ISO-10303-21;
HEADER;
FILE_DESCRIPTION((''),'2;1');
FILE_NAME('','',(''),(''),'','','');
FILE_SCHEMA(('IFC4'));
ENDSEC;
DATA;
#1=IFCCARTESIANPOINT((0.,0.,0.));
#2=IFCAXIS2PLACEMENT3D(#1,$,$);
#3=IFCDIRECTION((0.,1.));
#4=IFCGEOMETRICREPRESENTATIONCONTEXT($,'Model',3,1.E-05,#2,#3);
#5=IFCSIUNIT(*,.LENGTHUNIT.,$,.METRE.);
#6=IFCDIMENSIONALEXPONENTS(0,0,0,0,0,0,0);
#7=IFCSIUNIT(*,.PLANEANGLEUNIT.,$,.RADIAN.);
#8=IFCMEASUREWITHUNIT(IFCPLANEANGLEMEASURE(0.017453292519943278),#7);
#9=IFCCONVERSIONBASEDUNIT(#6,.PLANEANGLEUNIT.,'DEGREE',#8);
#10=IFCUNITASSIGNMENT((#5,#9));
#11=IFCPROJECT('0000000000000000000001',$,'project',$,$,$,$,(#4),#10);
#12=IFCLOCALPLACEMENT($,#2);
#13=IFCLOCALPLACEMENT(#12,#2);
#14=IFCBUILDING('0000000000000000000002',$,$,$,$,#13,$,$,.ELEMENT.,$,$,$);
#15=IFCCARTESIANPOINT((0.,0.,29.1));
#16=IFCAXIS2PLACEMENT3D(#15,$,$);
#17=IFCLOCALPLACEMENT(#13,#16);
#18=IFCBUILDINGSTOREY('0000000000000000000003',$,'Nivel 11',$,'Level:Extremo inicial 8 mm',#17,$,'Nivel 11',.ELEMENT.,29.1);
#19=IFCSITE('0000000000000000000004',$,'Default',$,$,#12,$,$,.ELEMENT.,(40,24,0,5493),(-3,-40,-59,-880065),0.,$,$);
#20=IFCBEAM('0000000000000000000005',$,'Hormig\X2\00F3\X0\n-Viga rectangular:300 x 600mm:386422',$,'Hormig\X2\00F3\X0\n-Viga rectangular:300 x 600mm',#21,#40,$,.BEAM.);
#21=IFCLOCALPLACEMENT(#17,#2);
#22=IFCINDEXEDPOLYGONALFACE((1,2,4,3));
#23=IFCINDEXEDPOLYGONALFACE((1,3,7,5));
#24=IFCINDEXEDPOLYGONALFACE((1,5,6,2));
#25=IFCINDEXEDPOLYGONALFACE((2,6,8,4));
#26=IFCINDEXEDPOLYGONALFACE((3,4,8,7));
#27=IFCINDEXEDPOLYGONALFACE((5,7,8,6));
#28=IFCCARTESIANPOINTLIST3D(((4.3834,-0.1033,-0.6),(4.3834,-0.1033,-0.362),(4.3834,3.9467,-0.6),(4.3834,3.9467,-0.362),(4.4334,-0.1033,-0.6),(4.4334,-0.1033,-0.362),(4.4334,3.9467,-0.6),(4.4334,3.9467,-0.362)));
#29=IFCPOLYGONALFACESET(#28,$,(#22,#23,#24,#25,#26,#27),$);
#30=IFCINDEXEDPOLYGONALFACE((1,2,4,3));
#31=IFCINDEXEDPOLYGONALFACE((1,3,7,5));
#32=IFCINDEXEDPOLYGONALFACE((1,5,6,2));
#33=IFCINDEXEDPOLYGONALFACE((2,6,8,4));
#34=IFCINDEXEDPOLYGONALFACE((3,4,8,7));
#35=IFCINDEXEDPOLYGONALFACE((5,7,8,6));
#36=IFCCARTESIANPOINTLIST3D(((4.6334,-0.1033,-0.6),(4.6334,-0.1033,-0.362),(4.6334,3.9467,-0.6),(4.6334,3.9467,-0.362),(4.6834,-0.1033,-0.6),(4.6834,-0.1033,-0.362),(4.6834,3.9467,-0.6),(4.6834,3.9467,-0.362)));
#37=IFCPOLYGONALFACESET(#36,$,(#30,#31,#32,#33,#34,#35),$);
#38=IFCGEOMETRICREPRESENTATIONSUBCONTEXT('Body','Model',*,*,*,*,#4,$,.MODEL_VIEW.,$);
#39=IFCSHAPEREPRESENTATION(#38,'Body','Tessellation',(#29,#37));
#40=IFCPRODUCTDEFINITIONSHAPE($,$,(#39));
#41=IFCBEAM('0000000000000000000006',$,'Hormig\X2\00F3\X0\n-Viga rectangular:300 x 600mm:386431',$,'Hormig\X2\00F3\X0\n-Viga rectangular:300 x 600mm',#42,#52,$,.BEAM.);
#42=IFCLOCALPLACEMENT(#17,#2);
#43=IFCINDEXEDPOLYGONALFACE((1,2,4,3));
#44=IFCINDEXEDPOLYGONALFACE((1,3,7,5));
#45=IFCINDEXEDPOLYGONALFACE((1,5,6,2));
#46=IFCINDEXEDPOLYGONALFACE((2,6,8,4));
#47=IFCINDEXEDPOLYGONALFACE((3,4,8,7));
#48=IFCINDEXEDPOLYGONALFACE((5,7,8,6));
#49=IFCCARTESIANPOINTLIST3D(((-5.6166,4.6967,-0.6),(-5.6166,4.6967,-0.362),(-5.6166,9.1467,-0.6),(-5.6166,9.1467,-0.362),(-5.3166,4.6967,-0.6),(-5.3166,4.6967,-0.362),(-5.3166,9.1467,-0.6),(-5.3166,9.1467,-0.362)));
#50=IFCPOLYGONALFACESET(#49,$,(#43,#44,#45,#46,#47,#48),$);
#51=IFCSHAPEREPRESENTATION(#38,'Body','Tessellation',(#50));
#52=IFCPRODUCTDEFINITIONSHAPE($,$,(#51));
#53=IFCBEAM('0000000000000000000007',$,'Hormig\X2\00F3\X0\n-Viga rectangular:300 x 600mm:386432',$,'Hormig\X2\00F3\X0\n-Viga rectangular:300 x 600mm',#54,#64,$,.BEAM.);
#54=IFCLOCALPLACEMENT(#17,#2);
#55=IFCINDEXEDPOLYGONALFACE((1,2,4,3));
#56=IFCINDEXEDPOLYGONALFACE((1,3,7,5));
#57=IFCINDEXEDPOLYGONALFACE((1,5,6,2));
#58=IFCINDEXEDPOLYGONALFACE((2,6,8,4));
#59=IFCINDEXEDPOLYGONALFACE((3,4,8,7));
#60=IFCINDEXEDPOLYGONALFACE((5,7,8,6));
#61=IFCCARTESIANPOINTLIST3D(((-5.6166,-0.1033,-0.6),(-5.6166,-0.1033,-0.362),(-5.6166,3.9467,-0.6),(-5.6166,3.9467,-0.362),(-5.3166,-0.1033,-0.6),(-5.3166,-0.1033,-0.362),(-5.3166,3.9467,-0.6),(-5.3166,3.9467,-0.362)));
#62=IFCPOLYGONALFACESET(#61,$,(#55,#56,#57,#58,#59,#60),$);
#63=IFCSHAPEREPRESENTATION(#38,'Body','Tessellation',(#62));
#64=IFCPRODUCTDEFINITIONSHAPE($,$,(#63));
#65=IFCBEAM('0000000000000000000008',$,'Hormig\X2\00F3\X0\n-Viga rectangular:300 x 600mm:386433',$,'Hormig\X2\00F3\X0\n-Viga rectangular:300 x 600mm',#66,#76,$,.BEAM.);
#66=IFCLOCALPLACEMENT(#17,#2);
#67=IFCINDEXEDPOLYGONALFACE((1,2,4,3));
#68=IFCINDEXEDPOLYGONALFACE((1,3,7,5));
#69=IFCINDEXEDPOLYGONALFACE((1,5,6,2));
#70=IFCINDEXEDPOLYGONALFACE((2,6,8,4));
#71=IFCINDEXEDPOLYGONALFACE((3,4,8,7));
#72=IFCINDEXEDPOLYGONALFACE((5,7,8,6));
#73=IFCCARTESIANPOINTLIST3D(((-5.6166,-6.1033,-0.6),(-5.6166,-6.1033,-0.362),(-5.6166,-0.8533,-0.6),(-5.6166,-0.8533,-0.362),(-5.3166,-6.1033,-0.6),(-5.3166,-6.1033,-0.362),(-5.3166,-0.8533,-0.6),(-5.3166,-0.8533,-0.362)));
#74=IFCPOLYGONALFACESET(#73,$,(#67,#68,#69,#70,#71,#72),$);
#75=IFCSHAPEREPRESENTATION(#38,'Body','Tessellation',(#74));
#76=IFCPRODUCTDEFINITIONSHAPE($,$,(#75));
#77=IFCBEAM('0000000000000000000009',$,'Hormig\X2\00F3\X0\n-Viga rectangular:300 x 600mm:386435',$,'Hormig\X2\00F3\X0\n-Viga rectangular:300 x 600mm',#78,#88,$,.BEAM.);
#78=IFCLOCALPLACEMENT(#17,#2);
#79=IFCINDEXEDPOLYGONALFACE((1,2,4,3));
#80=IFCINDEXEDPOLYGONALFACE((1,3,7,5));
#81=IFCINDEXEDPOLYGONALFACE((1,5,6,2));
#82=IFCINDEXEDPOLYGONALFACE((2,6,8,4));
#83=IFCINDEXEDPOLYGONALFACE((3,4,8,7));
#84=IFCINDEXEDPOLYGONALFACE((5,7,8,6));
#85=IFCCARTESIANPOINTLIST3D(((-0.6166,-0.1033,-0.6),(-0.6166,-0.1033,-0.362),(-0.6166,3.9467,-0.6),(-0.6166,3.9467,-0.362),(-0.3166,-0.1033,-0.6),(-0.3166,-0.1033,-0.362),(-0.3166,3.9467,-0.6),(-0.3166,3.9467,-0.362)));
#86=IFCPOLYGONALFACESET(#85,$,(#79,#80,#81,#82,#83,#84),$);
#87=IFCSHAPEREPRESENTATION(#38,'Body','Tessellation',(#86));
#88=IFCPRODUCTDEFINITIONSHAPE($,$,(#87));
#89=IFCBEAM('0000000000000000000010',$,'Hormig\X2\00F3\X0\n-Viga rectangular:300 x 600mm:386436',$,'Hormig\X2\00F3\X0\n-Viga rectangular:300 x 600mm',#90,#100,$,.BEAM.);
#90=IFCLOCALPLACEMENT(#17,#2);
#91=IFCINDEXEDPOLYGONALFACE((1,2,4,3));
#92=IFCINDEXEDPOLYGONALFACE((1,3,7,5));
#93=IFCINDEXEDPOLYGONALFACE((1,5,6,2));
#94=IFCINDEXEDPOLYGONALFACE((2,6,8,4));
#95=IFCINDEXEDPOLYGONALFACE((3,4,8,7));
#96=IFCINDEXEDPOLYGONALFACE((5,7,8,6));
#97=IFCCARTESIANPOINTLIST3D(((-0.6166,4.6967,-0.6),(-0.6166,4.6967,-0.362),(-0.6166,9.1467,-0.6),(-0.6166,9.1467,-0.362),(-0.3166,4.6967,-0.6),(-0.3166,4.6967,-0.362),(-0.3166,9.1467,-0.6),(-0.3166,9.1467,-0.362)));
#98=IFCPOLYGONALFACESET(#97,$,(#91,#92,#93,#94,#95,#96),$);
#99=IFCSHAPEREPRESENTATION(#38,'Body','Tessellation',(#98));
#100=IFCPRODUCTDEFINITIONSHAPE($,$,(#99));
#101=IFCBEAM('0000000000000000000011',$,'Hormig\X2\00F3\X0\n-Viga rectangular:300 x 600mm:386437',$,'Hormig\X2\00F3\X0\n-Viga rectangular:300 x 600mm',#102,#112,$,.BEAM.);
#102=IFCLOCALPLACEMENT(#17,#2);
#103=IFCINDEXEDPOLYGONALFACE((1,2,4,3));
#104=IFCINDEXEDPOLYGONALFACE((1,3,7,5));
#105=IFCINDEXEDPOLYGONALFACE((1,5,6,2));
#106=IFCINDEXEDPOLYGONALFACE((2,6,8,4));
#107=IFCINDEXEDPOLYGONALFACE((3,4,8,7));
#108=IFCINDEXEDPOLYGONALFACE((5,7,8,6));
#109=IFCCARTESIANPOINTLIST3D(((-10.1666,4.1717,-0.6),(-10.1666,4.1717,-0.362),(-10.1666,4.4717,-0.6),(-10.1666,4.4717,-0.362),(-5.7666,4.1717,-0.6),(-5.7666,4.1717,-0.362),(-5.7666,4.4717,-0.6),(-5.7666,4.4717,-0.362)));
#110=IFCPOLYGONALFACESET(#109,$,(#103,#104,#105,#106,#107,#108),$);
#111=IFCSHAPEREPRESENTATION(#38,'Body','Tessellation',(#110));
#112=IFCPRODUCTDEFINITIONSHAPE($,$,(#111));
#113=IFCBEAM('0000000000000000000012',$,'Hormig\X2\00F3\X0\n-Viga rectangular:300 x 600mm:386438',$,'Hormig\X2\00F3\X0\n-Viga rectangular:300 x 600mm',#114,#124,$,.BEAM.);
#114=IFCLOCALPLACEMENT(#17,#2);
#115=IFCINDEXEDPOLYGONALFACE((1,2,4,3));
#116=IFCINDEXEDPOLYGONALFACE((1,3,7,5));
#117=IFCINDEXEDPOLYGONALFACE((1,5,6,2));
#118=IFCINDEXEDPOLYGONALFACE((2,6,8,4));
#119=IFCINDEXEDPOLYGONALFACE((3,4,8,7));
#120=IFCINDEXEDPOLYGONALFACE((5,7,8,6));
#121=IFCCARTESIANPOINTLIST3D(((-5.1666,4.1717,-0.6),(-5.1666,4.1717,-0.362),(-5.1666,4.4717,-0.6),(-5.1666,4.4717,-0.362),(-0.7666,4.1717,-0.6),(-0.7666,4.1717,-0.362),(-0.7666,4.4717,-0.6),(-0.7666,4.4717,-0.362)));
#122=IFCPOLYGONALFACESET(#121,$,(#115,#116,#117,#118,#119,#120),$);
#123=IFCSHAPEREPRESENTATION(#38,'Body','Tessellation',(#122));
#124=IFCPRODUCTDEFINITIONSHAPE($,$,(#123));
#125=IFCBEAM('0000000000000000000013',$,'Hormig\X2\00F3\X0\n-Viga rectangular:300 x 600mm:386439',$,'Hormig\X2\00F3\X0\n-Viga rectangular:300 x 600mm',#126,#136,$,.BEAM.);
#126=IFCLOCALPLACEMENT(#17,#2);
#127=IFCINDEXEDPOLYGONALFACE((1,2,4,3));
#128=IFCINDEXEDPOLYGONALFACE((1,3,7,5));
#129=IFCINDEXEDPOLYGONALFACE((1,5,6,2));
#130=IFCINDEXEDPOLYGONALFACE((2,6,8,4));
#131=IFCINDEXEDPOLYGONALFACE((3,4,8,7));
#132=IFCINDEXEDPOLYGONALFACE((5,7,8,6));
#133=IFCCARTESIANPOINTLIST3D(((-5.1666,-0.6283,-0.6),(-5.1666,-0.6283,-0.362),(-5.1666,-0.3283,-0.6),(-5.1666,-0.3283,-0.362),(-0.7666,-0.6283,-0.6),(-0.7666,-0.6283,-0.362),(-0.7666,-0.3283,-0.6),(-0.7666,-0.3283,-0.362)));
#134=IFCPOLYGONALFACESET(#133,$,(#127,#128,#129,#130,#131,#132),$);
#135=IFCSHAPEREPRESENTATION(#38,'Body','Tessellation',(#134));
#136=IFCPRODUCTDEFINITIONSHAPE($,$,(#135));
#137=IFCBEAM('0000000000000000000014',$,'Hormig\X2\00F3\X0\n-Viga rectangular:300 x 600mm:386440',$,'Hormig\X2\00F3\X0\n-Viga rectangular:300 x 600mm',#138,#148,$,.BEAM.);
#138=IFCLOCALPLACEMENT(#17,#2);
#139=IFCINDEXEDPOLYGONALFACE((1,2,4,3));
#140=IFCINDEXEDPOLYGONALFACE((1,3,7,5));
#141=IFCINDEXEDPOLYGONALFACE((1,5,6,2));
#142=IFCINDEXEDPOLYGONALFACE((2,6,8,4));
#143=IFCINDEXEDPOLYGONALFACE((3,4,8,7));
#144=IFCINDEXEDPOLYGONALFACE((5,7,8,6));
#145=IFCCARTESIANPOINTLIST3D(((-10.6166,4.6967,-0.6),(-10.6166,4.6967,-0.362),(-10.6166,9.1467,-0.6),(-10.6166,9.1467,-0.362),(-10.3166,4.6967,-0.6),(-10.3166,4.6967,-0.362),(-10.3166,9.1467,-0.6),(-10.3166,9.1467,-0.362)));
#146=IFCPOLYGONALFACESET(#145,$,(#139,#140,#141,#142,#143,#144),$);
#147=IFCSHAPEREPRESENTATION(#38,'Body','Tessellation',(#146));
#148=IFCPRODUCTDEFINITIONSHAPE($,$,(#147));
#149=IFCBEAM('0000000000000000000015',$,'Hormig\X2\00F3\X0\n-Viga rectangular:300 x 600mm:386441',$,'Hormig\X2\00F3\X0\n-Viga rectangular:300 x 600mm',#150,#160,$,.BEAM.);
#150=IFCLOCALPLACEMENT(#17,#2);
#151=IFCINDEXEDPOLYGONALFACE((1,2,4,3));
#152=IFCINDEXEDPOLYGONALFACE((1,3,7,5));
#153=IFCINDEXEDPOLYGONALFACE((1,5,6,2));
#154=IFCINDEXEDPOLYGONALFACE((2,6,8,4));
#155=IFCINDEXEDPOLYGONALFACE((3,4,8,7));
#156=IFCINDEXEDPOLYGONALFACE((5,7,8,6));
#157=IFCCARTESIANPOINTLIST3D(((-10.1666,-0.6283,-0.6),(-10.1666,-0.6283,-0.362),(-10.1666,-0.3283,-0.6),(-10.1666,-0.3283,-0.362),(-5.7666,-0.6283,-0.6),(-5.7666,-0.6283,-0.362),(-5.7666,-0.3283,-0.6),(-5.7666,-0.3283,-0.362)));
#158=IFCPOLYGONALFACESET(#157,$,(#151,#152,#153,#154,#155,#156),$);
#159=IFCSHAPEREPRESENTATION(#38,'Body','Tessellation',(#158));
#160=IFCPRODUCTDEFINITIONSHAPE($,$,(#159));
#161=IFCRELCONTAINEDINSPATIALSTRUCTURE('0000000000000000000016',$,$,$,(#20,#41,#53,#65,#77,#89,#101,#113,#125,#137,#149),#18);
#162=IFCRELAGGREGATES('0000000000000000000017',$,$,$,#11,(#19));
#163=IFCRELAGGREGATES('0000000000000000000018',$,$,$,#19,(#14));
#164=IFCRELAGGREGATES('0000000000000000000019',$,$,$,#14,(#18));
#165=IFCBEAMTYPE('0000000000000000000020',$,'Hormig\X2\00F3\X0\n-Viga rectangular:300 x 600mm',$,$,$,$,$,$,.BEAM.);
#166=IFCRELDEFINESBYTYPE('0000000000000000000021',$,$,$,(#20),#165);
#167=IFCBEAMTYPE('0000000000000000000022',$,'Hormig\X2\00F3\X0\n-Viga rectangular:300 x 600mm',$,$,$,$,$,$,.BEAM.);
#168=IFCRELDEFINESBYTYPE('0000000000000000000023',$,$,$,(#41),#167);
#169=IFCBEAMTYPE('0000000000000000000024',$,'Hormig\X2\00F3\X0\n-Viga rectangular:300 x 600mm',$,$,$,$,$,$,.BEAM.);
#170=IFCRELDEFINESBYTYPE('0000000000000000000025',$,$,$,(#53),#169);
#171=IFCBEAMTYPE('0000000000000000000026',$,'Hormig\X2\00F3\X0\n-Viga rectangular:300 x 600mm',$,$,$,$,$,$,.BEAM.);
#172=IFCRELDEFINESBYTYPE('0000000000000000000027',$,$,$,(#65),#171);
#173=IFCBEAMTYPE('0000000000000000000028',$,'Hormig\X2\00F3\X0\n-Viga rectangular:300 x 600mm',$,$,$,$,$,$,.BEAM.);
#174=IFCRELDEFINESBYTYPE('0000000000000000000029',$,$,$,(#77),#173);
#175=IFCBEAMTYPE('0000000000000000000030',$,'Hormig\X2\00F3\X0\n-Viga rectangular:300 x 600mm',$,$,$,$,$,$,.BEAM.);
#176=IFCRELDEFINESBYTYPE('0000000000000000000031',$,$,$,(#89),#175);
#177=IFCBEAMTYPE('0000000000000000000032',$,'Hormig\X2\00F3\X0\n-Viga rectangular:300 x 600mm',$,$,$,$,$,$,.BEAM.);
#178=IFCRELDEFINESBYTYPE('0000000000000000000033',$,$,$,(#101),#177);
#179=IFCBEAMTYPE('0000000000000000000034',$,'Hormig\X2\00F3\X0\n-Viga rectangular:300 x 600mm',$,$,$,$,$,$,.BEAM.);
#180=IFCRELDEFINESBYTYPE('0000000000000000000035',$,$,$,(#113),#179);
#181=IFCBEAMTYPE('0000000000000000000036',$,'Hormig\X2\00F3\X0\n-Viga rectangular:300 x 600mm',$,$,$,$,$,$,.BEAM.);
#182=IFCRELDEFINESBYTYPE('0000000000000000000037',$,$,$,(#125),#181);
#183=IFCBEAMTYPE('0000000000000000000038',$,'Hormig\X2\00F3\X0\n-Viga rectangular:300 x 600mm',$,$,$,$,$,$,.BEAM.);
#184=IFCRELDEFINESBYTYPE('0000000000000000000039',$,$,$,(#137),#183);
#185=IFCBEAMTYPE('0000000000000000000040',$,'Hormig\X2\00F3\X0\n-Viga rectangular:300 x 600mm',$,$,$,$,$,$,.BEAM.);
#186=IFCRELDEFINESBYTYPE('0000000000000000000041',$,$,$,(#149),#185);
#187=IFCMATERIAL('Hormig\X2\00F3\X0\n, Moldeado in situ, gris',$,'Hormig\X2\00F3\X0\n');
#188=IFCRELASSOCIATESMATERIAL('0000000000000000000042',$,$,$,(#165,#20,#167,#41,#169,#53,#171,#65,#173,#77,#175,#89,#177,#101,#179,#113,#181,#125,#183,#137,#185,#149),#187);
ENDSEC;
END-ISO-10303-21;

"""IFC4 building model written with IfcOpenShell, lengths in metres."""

from ifc_helpers import new_model, entity, si_unit, converted_unit, direction, frame, origin, place, context, subcontext, project, spatial, indexed_curve, outline, extrude, source, transform, mapped, material, type_object, type_shapes, element, save


model = new_model("IFC4")

# Units and contexts
model_context = context("Model", 3, precision=1e-05, world=origin(), true_north=direction((0.0, 1.0)))
body_context = subcontext(model_context, "Body", "Model", "MODEL_VIEW")
ifc_project = project(units=[si_unit("LENGTHUNIT", "METRE"), converted_unit("PLANEANGLEUNIT", "DEGREE", entity("IfcPlaneAngleMeasure", 0.017453292519943278), si_unit("PLANEANGLEUNIT", "RADIAN"), dimensions=[0, 0, 0, 0, 0, 0, 0])], contexts=[model_context])

# Site, building, storey
site_placement = place(None, origin())
site = spatial("IfcSite", under=ifc_project, at=site_placement, Name="Default", CompositionType="ELEMENT", RefLatitude=(40, 24, 0, 5493), RefLongitude=(-3, -40, -59, -880065), RefElevation=0.0)
building_placement = place(site_placement, origin())
building = spatial("IfcBuilding", under=site, at=building_placement, CompositionType="ELEMENT")
storey_placement = place(building_placement, frame((0.0, 0.0, 29.1)))
storey = spatial("IfcBuildingStorey", under=building, at=storey_placement, Name="Nivel 11", ObjectType="Level:Extremo inicial 8 mm", LongName="Nivel 11", CompositionType="ELEMENT", Elevation=29.1)

# Shared definitions
ifc_material_1 = material(Name="Hormigón, Moldeado in situ, gris", Category="Hormigón")

# Beams
beam_type_1 = type_object("IfcBeamType", Name="Hormigón-Viga rectangular:300 x 600mm", PredefinedType="BEAM", material=ifc_material_1)
shared_shape_1 = source(origin(), body_context, "Body", "SweptSolid", [
    extrude(outline(indexed_curve([(-0.025, -0.119), (0.025, -0.119), (0.025, 0.119), (-0.025, 0.119), (-0.025, -0.119)], self_intersect=False)), frame((4.4084, 3.9467, 28.619), z_axis=(0.0, -1.0, 0.0), x_axis=(-1.0, 0.0, 0.0)), (0.0, 0.0, 1.0), 4.05),
    extrude(outline(indexed_curve([(-0.025, -0.119), (0.025, -0.119), (0.025, 0.119), (-0.025, 0.119), (-0.025, -0.119)], self_intersect=False)), frame((4.6584, 3.9467, 28.619), z_axis=(0.0, -1.0, 0.0), x_axis=(-1.0, 0.0, 0.0)), (0.0, 0.0, 1.0), 4.05),
])
type_shapes(beam_type_1, [shared_shape_1])
beam_1_placement = place(storey_placement, frame((0.0, 0.0, -29.1)))
element("IfcBeam", 1, at=beam_1_placement, inside=storey, type_object=beam_type_1, material=ifc_material_1, Name="Hormigón-Viga rectangular:300 x 600mm:386422", ObjectType="Hormigón-Viga rectangular:300 x 600mm", PredefinedType="BEAM", context=body_context, shape_type="MappedRepresentation", body=[
    mapped(shared_shape_1, transform((0.0, 0.0, 0.0), scale=1.0)),
])
beam_type_2 = type_object("IfcBeamType", Name="Hormigón-Viga rectangular:300 x 600mm", PredefinedType="BEAM", material=ifc_material_1)
shared_shape_2 = source(origin(), body_context, "Body", "SweptSolid", [
    extrude(outline(indexed_curve([(-0.15, -0.119), (0.15, -0.119), (0.15, 0.119), (-0.15, 0.119), (-0.15, -0.119)], self_intersect=False)), frame((-5.4666, 9.1467, 28.619), z_axis=(0.0, -1.0, 0.0), x_axis=(-1.0, 0.0, 0.0)), (0.0, 0.0, 1.0), 4.45),
])
type_shapes(beam_type_2, [shared_shape_2])
beam_2_placement = place(storey_placement, frame((0.0, 0.0, -29.1)))
element("IfcBeam", 2, at=beam_2_placement, inside=storey, type_object=beam_type_2, material=ifc_material_1, Name="Hormigón-Viga rectangular:300 x 600mm:386431", ObjectType="Hormigón-Viga rectangular:300 x 600mm", PredefinedType="BEAM", context=body_context, shape_type="MappedRepresentation", body=[
    mapped(shared_shape_2, transform((0.0, 0.0, 0.0), scale=1.0)),
])
beam_type_3 = type_object("IfcBeamType", Name="Hormigón-Viga rectangular:300 x 600mm", PredefinedType="BEAM", material=ifc_material_1)
shared_shape_3 = source(origin(), body_context, "Body", "SweptSolid", [
    extrude(outline(indexed_curve([(-0.15, -0.119), (0.15, -0.119), (0.15, 0.119), (-0.15, 0.119), (-0.15, -0.119)], self_intersect=False)), frame((-5.4666, 3.9467, 28.619), z_axis=(0.0, -1.0, 0.0), x_axis=(-1.0, 0.0, 0.0)), (0.0, 0.0, 1.0), 4.05),
])
type_shapes(beam_type_3, [shared_shape_3])
beam_3_placement = place(storey_placement, frame((0.0, 0.0, -29.1)))
element("IfcBeam", 3, at=beam_3_placement, inside=storey, type_object=beam_type_3, material=ifc_material_1, Name="Hormigón-Viga rectangular:300 x 600mm:386432", ObjectType="Hormigón-Viga rectangular:300 x 600mm", PredefinedType="BEAM", context=body_context, shape_type="MappedRepresentation", body=[
    mapped(shared_shape_3, transform((0.0, 0.0, 0.0), scale=1.0)),
])
beam_type_4 = type_object("IfcBeamType", Name="Hormigón-Viga rectangular:300 x 600mm", PredefinedType="BEAM", material=ifc_material_1)
shared_shape_4 = source(origin(), body_context, "Body", "SweptSolid", [
    extrude(outline(indexed_curve([(-0.15, -0.119), (0.15, -0.119), (0.15, 0.119), (-0.15, 0.119), (-0.15, -0.119)], self_intersect=False)), frame((-5.4666, -6.1033, 28.619), z_axis=(0.0, 1.0, 0.0), x_axis=(-1.0, 0.0, 0.0)), (0.0, 0.0, 1.0), 5.25),
])
type_shapes(beam_type_4, [shared_shape_4])
beam_4_placement = place(storey_placement, frame((0.0, 0.0, -29.1)))
element("IfcBeam", 4, at=beam_4_placement, inside=storey, type_object=beam_type_4, material=ifc_material_1, Name="Hormigón-Viga rectangular:300 x 600mm:386433", ObjectType="Hormigón-Viga rectangular:300 x 600mm", PredefinedType="BEAM", context=body_context, shape_type="MappedRepresentation", body=[
    mapped(shared_shape_4, transform((0.0, 0.0, 0.0), scale=1.0)),
])
beam_type_5 = type_object("IfcBeamType", Name="Hormigón-Viga rectangular:300 x 600mm", PredefinedType="BEAM", material=ifc_material_1)
shared_shape_5 = source(origin(), body_context, "Body", "SweptSolid", [
    extrude(outline(indexed_curve([(-0.15, -0.119), (0.15, -0.119), (0.15, 0.119), (-0.15, 0.119), (-0.15, -0.119)], self_intersect=False)), frame((-0.4666, -0.1033, 28.619), z_axis=(0.0, 1.0, 0.0), x_axis=(-1.0, 0.0, 0.0)), (0.0, 0.0, 1.0), 4.05),
])
type_shapes(beam_type_5, [shared_shape_5])
beam_5_placement = place(storey_placement, frame((0.0, 0.0, -29.1)))
element("IfcBeam", 5, at=beam_5_placement, inside=storey, type_object=beam_type_5, material=ifc_material_1, Name="Hormigón-Viga rectangular:300 x 600mm:386435", ObjectType="Hormigón-Viga rectangular:300 x 600mm", PredefinedType="BEAM", context=body_context, shape_type="MappedRepresentation", body=[
    mapped(shared_shape_5, transform((0.0, 0.0, 0.0), scale=1.0)),
])
beam_type_6 = type_object("IfcBeamType", Name="Hormigón-Viga rectangular:300 x 600mm", PredefinedType="BEAM", material=ifc_material_1)
shared_shape_6 = source(origin(), body_context, "Body", "SweptSolid", [
    extrude(outline(indexed_curve([(-0.15, -0.119), (0.15, -0.119), (0.15, 0.119), (-0.15, 0.119), (-0.15, -0.119)], self_intersect=False)), frame((-0.4666, 9.1467, 28.619), z_axis=(0.0, -1.0, 0.0), x_axis=(-1.0, 0.0, 0.0)), (0.0, 0.0, 1.0), 4.45),
])
type_shapes(beam_type_6, [shared_shape_6])
beam_6_placement = place(storey_placement, frame((0.0, 0.0, -29.1)))
element("IfcBeam", 6, at=beam_6_placement, inside=storey, type_object=beam_type_6, material=ifc_material_1, Name="Hormigón-Viga rectangular:300 x 600mm:386436", ObjectType="Hormigón-Viga rectangular:300 x 600mm", PredefinedType="BEAM", context=body_context, shape_type="MappedRepresentation", body=[
    mapped(shared_shape_6, transform((0.0, 0.0, 0.0), scale=1.0)),
])
beam_type_7 = type_object("IfcBeamType", Name="Hormigón-Viga rectangular:300 x 600mm", PredefinedType="BEAM", material=ifc_material_1)
shared_shape_7 = source(origin(), body_context, "Body", "SweptSolid", [
    extrude(outline(indexed_curve([(-0.119, -0.15), (0.119, -0.15), (0.119, 0.15), (-0.119, 0.15), (-0.119, -0.15)], self_intersect=False)), frame((-10.1666, 4.3217, 28.619), z_axis=(1.0, 0.0, 0.0), x_axis=(0.0, 0.0, -1.0)), (0.0, 0.0, 1.0), 4.4),
])
type_shapes(beam_type_7, [shared_shape_7])
beam_7_placement = place(storey_placement, frame((0.0, 0.0, -29.1)))
element("IfcBeam", 7, at=beam_7_placement, inside=storey, type_object=beam_type_7, material=ifc_material_1, Name="Hormigón-Viga rectangular:300 x 600mm:386437", ObjectType="Hormigón-Viga rectangular:300 x 600mm", PredefinedType="BEAM", context=body_context, shape_type="MappedRepresentation", body=[
    mapped(shared_shape_7, transform((0.0, 0.0, 0.0), scale=1.0)),
])
beam_type_8 = type_object("IfcBeamType", Name="Hormigón-Viga rectangular:300 x 600mm", PredefinedType="BEAM", material=ifc_material_1)
shared_shape_8 = source(origin(), body_context, "Body", "SweptSolid", [
    extrude(outline(indexed_curve([(-0.119, -0.15), (0.119, -0.15), (0.119, 0.15), (-0.119, 0.15), (-0.119, -0.15)], self_intersect=False)), frame((-5.1666, 4.3217, 28.619), z_axis=(1.0, 0.0, 0.0), x_axis=(0.0, 0.0, -1.0)), (0.0, 0.0, 1.0), 4.4),
])
type_shapes(beam_type_8, [shared_shape_8])
beam_8_placement = place(storey_placement, frame((0.0, 0.0, -29.1)))
element("IfcBeam", 8, at=beam_8_placement, inside=storey, type_object=beam_type_8, material=ifc_material_1, Name="Hormigón-Viga rectangular:300 x 600mm:386438", ObjectType="Hormigón-Viga rectangular:300 x 600mm", PredefinedType="BEAM", context=body_context, shape_type="MappedRepresentation", body=[
    mapped(shared_shape_8, transform((0.0, 0.0, 0.0), scale=1.0)),
])
beam_type_9 = type_object("IfcBeamType", Name="Hormigón-Viga rectangular:300 x 600mm", PredefinedType="BEAM", material=ifc_material_1)
shared_shape_9 = source(origin(), body_context, "Body", "SweptSolid", [
    extrude(outline(indexed_curve([(-0.119, -0.15), (0.119, -0.15), (0.119, 0.15), (-0.119, 0.15), (-0.119, -0.15)], self_intersect=False)), frame((-0.7666, -0.4783, 28.619), z_axis=(-1.0, 0.0, 0.0), x_axis=(0.0, 0.0, -1.0)), (0.0, 0.0, 1.0), 4.4),
])
type_shapes(beam_type_9, [shared_shape_9])
beam_9_placement = place(storey_placement, frame((0.0, 0.0, -29.1)))
element("IfcBeam", 9, at=beam_9_placement, inside=storey, type_object=beam_type_9, material=ifc_material_1, Name="Hormigón-Viga rectangular:300 x 600mm:386439", ObjectType="Hormigón-Viga rectangular:300 x 600mm", PredefinedType="BEAM", context=body_context, shape_type="MappedRepresentation", body=[
    mapped(shared_shape_9, transform((0.0, 0.0, 0.0), scale=1.0)),
])
beam_type_10 = type_object("IfcBeamType", Name="Hormigón-Viga rectangular:300 x 600mm", PredefinedType="BEAM", material=ifc_material_1)
shared_shape_10 = source(origin(), body_context, "Body", "SweptSolid", [
    extrude(outline(indexed_curve([(-0.15, -0.119), (0.15, -0.119), (0.15, 0.119), (-0.15, 0.119), (-0.15, -0.119)], self_intersect=False)), frame((-10.4666, 4.6967, 28.619), z_axis=(0.0, 1.0, 0.0), x_axis=(-1.0, 0.0, 0.0)), (0.0, 0.0, 1.0), 4.45),
])
type_shapes(beam_type_10, [shared_shape_10])
beam_10_placement = place(storey_placement, frame((0.0, 0.0, -29.1)))
element("IfcBeam", 10, at=beam_10_placement, inside=storey, type_object=beam_type_10, material=ifc_material_1, Name="Hormigón-Viga rectangular:300 x 600mm:386440", ObjectType="Hormigón-Viga rectangular:300 x 600mm", PredefinedType="BEAM", context=body_context, shape_type="MappedRepresentation", body=[
    mapped(shared_shape_10, transform((0.0, 0.0, 0.0), scale=1.0)),
])
beam_type_11 = type_object("IfcBeamType", Name="Hormigón-Viga rectangular:300 x 600mm", PredefinedType="BEAM", material=ifc_material_1)
shared_shape_11 = source(origin(), body_context, "Body", "SweptSolid", [
    extrude(outline(indexed_curve([(-0.119, -0.15), (0.119, -0.15), (0.119, 0.15), (-0.119, 0.15), (-0.119, -0.15)], self_intersect=False)), frame((-10.1666, -0.4783, 28.619), z_axis=(1.0, 0.0, 0.0), x_axis=(0.0, 0.0, -1.0)), (0.0, 0.0, 1.0), 4.4),
])
type_shapes(beam_type_11, [shared_shape_11])
beam_11_placement = place(storey_placement, frame((0.0, 0.0, -29.1)))
element("IfcBeam", 11, at=beam_11_placement, inside=storey, type_object=beam_type_11, material=ifc_material_1, Name="Hormigón-Viga rectangular:300 x 600mm:386441", ObjectType="Hormigón-Viga rectangular:300 x 600mm", PredefinedType="BEAM", context=body_context, shape_type="MappedRepresentation", body=[
    mapped(shared_shape_11, transform((0.0, 0.0, 0.0), scale=1.0)),
])

save(model, "model.ifc")
